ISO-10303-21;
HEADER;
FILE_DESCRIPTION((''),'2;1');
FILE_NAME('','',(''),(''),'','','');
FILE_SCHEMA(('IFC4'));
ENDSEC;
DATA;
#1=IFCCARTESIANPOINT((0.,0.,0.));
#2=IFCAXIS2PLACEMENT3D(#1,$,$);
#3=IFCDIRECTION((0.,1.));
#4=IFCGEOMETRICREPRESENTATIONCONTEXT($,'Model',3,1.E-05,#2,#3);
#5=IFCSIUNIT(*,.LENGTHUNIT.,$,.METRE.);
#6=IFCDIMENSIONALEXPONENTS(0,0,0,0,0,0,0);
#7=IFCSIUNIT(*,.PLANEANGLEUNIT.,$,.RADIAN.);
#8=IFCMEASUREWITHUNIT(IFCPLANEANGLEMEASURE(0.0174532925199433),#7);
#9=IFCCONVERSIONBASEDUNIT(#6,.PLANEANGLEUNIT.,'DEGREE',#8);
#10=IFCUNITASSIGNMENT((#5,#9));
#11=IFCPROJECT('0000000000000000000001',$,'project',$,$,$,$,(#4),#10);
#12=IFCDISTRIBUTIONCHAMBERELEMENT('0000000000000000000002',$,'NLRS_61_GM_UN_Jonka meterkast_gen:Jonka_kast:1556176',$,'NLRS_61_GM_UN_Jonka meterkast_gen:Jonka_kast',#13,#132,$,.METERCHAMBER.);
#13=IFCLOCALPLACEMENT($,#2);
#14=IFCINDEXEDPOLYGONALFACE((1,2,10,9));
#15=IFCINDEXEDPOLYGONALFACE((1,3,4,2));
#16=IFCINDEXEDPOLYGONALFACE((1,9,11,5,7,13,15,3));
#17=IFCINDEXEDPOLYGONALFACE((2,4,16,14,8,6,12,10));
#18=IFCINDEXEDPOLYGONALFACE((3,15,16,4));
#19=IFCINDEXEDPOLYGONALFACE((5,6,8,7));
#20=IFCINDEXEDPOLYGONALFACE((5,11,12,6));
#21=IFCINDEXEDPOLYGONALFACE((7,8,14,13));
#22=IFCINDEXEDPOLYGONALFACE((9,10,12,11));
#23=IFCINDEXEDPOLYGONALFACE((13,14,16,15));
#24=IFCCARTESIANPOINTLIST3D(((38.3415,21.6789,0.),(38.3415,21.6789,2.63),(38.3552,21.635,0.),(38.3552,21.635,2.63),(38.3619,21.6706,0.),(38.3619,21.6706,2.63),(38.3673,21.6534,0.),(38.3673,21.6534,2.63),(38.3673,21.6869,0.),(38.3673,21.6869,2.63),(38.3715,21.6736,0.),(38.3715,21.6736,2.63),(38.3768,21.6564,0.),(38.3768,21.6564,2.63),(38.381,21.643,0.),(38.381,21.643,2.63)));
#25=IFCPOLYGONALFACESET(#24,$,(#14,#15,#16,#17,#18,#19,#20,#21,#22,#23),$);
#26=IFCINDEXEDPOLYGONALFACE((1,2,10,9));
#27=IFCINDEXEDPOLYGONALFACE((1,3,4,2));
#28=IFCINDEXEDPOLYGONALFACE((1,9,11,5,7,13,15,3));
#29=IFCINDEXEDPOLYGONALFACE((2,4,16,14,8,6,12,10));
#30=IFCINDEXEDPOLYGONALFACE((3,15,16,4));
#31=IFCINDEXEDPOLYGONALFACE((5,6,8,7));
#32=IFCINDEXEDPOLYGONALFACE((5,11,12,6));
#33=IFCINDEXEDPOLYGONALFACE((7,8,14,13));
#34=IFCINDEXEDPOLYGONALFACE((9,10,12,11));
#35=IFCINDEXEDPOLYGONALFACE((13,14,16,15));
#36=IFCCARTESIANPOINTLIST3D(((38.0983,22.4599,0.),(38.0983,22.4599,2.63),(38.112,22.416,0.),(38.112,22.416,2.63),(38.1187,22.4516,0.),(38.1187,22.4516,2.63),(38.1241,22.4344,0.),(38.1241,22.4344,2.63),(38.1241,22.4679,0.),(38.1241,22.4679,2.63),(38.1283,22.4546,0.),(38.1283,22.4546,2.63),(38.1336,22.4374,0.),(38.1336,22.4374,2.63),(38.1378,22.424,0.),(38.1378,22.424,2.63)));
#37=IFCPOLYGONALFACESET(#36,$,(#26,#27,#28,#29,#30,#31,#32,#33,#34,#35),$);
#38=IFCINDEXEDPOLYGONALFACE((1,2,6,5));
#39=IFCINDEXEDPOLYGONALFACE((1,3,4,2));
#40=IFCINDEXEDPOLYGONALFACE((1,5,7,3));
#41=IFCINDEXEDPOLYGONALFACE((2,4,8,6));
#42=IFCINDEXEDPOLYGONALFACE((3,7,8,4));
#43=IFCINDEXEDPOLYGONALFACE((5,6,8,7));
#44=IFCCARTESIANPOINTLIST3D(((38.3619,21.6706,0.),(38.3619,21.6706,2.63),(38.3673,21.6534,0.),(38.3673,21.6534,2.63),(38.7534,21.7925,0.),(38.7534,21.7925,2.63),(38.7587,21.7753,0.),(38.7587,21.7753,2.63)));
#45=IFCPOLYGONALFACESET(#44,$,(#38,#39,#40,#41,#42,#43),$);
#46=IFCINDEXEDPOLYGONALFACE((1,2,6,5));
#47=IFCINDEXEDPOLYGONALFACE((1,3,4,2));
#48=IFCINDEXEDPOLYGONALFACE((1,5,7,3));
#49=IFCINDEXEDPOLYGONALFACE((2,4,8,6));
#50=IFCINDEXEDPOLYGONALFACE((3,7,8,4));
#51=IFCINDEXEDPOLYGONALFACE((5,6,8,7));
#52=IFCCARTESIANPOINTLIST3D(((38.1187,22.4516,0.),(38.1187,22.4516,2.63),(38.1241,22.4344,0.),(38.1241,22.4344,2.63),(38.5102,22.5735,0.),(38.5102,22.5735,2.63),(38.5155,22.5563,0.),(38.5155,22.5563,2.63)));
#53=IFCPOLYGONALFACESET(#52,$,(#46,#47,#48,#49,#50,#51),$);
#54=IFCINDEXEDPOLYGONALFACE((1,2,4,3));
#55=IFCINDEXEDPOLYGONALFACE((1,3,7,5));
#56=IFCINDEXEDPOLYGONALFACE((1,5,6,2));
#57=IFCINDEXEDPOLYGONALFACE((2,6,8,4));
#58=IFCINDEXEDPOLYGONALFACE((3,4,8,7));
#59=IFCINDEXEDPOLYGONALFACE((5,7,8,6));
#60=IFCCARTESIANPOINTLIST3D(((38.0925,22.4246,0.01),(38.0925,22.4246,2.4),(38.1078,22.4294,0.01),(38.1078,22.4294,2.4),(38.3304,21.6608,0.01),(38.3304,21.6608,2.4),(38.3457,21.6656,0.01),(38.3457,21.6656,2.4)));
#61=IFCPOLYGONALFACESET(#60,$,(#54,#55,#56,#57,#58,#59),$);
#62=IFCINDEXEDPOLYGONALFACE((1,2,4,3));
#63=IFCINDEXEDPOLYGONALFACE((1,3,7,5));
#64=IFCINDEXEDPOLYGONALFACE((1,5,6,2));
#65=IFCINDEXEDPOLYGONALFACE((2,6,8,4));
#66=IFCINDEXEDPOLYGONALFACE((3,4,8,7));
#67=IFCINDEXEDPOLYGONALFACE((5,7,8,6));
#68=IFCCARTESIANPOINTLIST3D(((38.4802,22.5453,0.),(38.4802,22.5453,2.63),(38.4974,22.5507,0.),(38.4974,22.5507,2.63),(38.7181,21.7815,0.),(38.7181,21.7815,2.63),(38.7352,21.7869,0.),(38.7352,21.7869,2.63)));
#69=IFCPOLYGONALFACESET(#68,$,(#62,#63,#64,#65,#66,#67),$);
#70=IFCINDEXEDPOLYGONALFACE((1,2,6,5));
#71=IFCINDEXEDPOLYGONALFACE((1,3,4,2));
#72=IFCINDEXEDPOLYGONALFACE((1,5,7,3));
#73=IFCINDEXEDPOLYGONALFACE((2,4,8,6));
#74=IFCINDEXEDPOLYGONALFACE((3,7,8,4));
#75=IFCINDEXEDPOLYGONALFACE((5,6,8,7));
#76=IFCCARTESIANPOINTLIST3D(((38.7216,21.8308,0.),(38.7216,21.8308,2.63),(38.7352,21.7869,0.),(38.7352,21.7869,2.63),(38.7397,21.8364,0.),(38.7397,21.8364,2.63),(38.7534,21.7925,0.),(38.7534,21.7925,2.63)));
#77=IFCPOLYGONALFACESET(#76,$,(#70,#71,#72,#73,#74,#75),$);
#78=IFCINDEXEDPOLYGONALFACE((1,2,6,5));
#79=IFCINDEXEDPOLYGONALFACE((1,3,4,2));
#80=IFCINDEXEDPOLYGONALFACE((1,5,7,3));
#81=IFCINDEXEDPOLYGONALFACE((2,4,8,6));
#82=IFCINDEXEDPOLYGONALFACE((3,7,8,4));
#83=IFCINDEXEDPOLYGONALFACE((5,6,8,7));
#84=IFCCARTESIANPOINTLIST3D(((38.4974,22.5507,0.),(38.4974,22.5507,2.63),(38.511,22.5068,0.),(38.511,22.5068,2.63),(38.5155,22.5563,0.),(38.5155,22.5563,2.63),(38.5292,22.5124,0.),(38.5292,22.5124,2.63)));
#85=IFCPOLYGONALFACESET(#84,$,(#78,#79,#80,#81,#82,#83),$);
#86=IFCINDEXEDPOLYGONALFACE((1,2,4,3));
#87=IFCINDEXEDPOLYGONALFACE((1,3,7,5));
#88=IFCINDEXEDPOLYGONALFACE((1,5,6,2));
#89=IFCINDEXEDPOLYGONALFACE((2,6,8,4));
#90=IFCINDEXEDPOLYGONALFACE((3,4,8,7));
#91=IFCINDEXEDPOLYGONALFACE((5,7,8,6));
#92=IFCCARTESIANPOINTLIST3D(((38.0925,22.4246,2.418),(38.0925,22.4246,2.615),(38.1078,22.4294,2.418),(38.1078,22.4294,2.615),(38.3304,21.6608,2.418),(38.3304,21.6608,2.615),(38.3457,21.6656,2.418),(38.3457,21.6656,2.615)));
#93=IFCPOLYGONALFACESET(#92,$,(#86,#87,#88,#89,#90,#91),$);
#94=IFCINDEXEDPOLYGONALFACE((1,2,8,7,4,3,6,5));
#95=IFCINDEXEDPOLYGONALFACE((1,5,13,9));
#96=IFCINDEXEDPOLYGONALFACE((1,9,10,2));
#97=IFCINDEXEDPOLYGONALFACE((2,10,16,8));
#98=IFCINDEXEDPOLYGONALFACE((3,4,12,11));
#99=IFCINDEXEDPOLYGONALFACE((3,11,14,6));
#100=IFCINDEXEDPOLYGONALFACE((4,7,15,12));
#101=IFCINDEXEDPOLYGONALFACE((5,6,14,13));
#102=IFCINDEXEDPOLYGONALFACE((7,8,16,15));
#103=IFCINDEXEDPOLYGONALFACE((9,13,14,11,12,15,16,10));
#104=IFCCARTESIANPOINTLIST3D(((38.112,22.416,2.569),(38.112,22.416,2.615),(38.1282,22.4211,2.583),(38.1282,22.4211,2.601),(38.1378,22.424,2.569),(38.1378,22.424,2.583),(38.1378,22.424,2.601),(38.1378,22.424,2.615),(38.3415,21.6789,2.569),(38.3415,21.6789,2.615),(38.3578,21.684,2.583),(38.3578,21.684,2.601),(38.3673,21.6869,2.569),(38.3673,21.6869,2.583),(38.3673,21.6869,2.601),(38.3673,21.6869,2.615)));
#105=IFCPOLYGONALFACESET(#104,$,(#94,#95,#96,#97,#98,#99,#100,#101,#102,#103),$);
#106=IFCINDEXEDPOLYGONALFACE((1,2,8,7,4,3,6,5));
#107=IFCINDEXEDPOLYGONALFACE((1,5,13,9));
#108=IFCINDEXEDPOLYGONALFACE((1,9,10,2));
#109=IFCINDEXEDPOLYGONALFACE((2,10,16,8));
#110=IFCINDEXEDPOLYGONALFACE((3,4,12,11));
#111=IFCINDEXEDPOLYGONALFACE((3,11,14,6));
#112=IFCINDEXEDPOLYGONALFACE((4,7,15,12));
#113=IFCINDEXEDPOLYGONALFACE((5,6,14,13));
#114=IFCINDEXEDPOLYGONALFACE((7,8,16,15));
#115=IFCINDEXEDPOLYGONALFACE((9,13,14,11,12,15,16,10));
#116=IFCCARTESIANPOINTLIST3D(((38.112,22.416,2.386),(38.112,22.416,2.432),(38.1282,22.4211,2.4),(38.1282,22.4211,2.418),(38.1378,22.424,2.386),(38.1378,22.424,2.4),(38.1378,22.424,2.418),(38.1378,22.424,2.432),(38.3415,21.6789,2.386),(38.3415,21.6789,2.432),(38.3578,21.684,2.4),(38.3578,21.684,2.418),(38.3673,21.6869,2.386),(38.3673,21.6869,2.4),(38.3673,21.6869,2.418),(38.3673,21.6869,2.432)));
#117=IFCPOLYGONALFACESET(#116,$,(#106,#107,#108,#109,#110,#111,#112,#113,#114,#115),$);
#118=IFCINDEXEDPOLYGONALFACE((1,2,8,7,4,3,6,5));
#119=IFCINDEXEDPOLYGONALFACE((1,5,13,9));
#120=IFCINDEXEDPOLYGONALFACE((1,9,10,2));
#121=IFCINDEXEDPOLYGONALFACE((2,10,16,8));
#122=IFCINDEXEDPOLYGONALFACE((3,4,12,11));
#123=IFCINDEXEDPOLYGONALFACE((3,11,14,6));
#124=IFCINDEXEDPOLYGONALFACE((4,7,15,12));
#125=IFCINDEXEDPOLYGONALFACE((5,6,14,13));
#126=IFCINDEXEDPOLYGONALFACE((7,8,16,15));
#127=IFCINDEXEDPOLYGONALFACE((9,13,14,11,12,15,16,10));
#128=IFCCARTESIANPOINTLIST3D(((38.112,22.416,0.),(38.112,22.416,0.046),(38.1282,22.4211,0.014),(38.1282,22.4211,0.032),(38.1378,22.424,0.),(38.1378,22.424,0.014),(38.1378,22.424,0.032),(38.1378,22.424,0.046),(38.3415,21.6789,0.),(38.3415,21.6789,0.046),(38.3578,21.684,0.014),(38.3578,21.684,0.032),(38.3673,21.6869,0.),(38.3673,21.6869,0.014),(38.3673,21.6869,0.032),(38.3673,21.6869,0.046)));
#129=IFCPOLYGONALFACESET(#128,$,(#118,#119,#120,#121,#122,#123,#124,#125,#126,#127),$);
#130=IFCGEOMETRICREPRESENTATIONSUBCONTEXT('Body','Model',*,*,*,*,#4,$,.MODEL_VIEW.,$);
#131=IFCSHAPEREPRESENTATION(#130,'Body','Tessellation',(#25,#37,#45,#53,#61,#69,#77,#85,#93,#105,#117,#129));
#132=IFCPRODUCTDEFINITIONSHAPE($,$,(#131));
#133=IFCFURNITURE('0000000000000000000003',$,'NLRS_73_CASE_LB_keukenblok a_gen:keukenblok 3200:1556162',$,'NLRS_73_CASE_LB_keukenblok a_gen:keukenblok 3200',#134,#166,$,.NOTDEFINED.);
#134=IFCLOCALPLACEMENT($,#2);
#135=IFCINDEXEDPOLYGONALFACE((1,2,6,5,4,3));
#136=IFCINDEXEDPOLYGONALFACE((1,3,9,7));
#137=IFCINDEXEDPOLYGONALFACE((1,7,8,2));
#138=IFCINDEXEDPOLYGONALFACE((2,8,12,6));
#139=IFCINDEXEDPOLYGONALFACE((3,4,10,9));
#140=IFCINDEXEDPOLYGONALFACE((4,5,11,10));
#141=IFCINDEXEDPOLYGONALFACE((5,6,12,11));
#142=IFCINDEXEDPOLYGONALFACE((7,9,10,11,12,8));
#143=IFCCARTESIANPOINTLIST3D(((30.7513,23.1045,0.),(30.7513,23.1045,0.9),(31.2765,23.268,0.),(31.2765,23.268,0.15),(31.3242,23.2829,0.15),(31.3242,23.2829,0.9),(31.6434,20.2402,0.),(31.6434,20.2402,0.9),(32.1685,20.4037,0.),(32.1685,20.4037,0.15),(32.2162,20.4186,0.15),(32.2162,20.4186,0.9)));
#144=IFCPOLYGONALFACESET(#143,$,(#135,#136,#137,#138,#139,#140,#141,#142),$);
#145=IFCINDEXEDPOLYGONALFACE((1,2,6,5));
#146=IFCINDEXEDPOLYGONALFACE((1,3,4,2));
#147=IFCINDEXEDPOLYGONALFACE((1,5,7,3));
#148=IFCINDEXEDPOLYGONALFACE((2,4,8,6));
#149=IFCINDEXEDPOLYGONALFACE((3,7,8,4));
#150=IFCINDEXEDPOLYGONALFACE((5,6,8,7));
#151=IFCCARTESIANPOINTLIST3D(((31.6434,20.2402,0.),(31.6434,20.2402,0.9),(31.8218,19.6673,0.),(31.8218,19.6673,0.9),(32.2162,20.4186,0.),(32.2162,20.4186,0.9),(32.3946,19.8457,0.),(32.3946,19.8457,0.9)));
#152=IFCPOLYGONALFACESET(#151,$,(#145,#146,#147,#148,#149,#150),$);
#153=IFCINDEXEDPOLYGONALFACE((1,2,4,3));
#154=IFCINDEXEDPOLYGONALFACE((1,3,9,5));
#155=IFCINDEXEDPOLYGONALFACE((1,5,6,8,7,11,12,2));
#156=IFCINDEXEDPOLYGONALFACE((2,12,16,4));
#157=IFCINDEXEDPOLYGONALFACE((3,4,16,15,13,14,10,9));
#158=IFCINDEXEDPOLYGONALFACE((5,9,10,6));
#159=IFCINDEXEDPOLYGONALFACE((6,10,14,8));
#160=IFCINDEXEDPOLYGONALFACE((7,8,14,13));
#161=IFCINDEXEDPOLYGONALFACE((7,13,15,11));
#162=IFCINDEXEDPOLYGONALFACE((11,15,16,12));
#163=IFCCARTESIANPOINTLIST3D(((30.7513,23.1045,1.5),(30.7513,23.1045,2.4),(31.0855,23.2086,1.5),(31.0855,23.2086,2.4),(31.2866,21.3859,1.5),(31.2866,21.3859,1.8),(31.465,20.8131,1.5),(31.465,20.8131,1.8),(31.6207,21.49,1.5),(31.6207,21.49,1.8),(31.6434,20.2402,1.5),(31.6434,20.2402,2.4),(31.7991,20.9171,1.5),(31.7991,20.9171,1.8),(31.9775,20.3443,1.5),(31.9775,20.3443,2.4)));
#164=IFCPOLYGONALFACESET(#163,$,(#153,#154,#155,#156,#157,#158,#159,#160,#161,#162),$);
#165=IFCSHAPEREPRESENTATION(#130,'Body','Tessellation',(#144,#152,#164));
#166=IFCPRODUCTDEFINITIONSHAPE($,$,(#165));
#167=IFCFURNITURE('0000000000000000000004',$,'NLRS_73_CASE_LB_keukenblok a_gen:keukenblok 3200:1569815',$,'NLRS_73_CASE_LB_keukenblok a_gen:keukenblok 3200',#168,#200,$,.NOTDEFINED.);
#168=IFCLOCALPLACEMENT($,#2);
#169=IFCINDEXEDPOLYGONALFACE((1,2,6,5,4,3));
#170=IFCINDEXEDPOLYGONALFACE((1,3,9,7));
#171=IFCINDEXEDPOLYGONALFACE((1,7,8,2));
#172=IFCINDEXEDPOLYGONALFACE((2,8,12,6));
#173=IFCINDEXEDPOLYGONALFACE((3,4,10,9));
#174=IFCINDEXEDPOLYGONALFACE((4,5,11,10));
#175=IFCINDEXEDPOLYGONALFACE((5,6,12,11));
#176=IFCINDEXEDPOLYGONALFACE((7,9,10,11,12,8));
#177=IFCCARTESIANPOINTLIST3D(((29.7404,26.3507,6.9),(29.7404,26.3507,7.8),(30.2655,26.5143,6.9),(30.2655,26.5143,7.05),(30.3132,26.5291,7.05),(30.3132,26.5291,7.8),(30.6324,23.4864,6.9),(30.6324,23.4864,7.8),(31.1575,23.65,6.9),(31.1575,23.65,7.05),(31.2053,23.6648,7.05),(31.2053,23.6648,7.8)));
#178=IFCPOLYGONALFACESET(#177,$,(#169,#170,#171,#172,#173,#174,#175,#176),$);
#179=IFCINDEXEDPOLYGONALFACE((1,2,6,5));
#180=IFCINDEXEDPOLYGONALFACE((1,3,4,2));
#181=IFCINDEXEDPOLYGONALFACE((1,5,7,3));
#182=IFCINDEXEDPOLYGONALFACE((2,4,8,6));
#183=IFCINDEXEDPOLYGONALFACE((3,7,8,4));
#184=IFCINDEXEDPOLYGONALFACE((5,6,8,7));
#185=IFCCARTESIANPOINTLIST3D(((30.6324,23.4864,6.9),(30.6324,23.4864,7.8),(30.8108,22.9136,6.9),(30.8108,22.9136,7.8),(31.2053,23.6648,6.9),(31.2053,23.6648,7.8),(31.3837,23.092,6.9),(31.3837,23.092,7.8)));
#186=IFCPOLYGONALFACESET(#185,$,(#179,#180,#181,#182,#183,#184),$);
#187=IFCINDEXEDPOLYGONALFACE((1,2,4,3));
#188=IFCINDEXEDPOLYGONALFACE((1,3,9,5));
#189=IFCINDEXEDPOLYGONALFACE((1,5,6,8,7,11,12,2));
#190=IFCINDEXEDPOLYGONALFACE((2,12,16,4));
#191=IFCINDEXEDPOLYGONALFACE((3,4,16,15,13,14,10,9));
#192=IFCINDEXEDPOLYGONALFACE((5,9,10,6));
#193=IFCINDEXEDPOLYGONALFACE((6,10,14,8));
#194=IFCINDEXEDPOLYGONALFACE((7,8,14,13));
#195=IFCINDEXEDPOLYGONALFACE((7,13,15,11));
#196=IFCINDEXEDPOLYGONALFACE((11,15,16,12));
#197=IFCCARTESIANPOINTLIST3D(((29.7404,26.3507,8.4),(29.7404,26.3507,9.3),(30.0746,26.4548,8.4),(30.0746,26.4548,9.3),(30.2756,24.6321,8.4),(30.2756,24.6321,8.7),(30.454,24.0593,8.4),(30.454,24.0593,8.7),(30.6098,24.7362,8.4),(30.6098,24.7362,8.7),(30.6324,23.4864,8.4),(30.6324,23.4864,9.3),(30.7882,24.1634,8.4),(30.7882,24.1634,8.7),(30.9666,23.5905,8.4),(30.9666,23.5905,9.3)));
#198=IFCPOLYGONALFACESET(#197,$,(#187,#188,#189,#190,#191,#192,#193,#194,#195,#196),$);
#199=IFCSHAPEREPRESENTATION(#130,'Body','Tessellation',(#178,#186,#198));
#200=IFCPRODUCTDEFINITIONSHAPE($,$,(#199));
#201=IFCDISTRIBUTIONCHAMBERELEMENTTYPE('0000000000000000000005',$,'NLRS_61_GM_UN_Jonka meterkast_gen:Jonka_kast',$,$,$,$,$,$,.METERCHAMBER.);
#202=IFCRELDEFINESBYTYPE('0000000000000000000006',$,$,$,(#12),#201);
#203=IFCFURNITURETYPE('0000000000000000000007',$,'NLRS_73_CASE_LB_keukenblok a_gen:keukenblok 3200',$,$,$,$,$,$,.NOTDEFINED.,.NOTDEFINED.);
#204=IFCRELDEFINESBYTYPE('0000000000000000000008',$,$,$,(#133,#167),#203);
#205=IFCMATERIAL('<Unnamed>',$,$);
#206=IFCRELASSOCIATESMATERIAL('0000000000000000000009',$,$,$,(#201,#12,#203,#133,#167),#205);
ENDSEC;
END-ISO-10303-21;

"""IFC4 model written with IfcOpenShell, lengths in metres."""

from ifc_helpers import new_model, entity, si_unit, converted_unit, direction, frame, origin, place, context, subcontext, project, indexed_curve, outline, extrude, source, transform, mapped, material, type_object, type_shapes, element, save


model = new_model("IFC4")

# Units and contexts
model_context = context("Model", 3, precision=1e-05, world=origin(), true_north=direction((0.0, 1.0)))
body_context = subcontext(model_context, "Body", "Model", "MODEL_VIEW")
ifc_project = project(units=[si_unit("LENGTHUNIT", "METRE"), converted_unit("PLANEANGLEUNIT", "DEGREE", entity("IfcPlaneAngleMeasure", 0.0174532925199433), si_unit("PLANEANGLEUNIT", "RADIAN"), dimensions=[0, 0, 0, 0, 0, 0, 0])], contexts=[model_context])

# Shared definitions
ifc_material = material(Name="<Unnamed>")
distribution_chamber_element_type = type_object("IfcDistributionChamberElementType", Name="NLRS_61_GM_UN_Jonka meterkast_gen:Jonka_kast", PredefinedType="METERCHAMBER", material=ifc_material)
placement_1 = place(None, frame((13.1348, 11.9886, 0.0), z_axis=(0.0, 0.0, 1.0), x_axis=(0.954771, 0.297342, 0.0)))
placement_2 = place(placement_1, origin())
placement_3 = place(placement_2, frame((0.0, 0.0, 6.9)))

# Distribution chamber element
shared_shape_1 = source(origin(), body_context, "Body", "SweptSolid", [
    extrude(outline(indexed_curve([(-0.023, -0.0093), (-0.009, -0.0093), (-0.009, 0.0007), (0.009, 0.0007), (0.009, -0.0093), (0.023, -0.0093), (0.023, 0.0178), (-0.023, 0.0178), (-0.023, -0.0093)], self_intersect=False)), frame((-0.409, 0.4092, 0.0)), (0.0, 0.0, 1.0), 2.63),
    extrude(outline(indexed_curve([(-0.023, -0.0093), (-0.009, -0.0093), (-0.009, 0.0007), (0.009, 0.0007), (0.009, -0.0093), (0.023, -0.0093), (0.023, 0.0178), (-0.023, 0.0178), (-0.023, -0.0093)], self_intersect=False)), frame((0.409, 0.4092, 0.0)), (0.0, 0.0, 1.0), 2.63),
    extrude(outline(indexed_curve([(-0.009, -0.205), (0.009, -0.205), (0.009, 0.205), (-0.009, 0.205), (-0.009, -0.205)], self_intersect=False)), frame((-0.409, 0.205, 0.0)), (0.0, 0.0, 1.0), 2.63),
    extrude(outline(indexed_curve([(-0.009, -0.205), (0.009, -0.205), (0.009, 0.205), (-0.009, 0.205), (-0.009, -0.205)], self_intersect=False)), frame((0.409, 0.205, 0.0)), (0.0, 0.0, 1.0), 2.63),
    extrude(outline(indexed_curve([(-0.008, -0.4), (0.008, -0.4), (0.008, 0.4), (-0.008, 0.4), (-0.008, -0.4)], self_intersect=False)), frame((0.0, 0.435, 0.01), z_axis=(0.0, 0.0, 1.0), x_axis=(0.0, 1.0, 0.0)), (0.0, 0.0, 1.0), 2.39),
    extrude(outline(indexed_curve([(-0.009, -0.4), (0.009, -0.4), (0.009, 0.4), (-0.009, 0.4), (-0.009, -0.4)], self_intersect=False)), frame((0.0, 0.028, 0.0), z_axis=(0.0, 0.0, 1.0), x_axis=(0.0, 1.0, 0.0)), (0.0, 0.0, 1.0), 2.63),
    extrude(outline(indexed_curve([(-0.0095, -0.023), (0.0095, -0.023), (0.0095, 0.023), (-0.0095, 0.023), (-0.0095, -0.023)], self_intersect=False)), frame((-0.377, 0.0095, 0.0), z_axis=(0.0, 0.0, 1.0), x_axis=(0.0, 1.0, 0.0)), (0.0, 0.0, 1.0), 2.63),
    extrude(outline(indexed_curve([(-0.0095, -0.023), (0.0095, -0.023), (0.0095, 0.023), (-0.0095, 0.023), (-0.0095, -0.023)], self_intersect=False)), frame((0.377, 0.0095, 0.0), z_axis=(0.0, 0.0, 1.0), x_axis=(0.0, 1.0, 0.0)), (0.0, 0.0, 1.0), 2.63),
    extrude(outline(indexed_curve([(-0.008, -0.4), (0.008, -0.4), (0.008, 0.4), (-0.008, 0.4), (-0.008, -0.4)], self_intersect=False)), frame((0.0, 0.435, 2.418), z_axis=(0.0, 0.0, 1.0), x_axis=(0.0, 1.0, 0.0)), (0.0, 0.0, 1.0), 0.197),
    extrude(outline(indexed_curve([(-0.0178, -0.023), (0.0093, -0.023), (0.0093, -0.009), (-0.0007, -0.009), (-0.0007, 0.009), (0.0093, 0.009), (0.0093, 0.023), (-0.0178, 0.023), (-0.0178, -0.023)], self_intersect=False)), frame((-0.386, 0.4092, 2.592), z_axis=(1.0, 0.0, 0.0), x_axis=(0.0, -1.0, 0.0)), (0.0, 0.0, 1.0), 0.772),
    extrude(outline(indexed_curve([(-0.0178, -0.023), (0.0093, -0.023), (0.0093, -0.009), (-0.0007, -0.009), (-0.0007, 0.009), (0.0093, 0.009), (0.0093, 0.023), (-0.0178, 0.023), (-0.0178, -0.023)], self_intersect=False)), frame((-0.386, 0.4092, 2.409), z_axis=(1.0, 0.0, 0.0), x_axis=(0.0, -1.0, 0.0)), (0.0, 0.0, 1.0), 0.772),
    extrude(outline(indexed_curve([(-0.0178, -0.023), (0.0093, -0.023), (0.0093, -0.009), (-0.0007, -0.009), (-0.0007, 0.009), (0.0093, 0.009), (0.0093, 0.023), (-0.0178, 0.023), (-0.0178, -0.023)], self_intersect=False)), frame((-0.386, 0.4092, 0.023), z_axis=(1.0, 0.0, 0.0), x_axis=(0.0, -1.0, 0.0)), (0.0, 0.0, 1.0), 0.772),
])
placement_4 = place(placement_2, origin())
placement_5 = place(placement_4, origin())
distribution_chamber_element_1_placement = place(placement_5, frame((27.375, 2.143, 0.0), z_axis=(0.0, 0.0, 1.0), x_axis=(0.0, 1.0, 0.0)))
element("IfcDistributionChamberElement", 1, at=distribution_chamber_element_1_placement, type_object=distribution_chamber_element_type, material=ifc_material, Name="NLRS_61_GM_UN_Jonka meterkast_gen:Jonka_kast:1556176", ObjectType="NLRS_61_GM_UN_Jonka meterkast_gen:Jonka_kast", PredefinedType="METERCHAMBER", context=body_context, shape_type="MappedRepresentation", body=[
    mapped(shared_shape_1, transform((0.0, 0.0, 0.0), scale=1.0)),
])

# Furniture
furniture_type = type_object("IfcFurnitureType", Name="NLRS_73_CASE_LB_keukenblok a_gen:keukenblok 3200", AssemblyPlace="NOTDEFINED", PredefinedType="NOTDEFINED", material=ifc_material)
shared_shape_2 = source(origin(), body_context, "Body", "SweptSolid", [
    extrude(outline(indexed_curve([(-0.35, 0.1667), (-0.35, -0.3833), (0.55, -0.3833), (0.55, 0.2167), (-0.2, 0.2167), (-0.2, 0.1667), (-0.35, 0.1667)], self_intersect=False)), frame((0.0, 0.3833, 0.35), z_axis=(-1.0, 0.0, 0.0), x_axis=(0.0, 0.0, 1.0)), (0.0, 0.0, -1.0), 3.0),
    extrude(outline(indexed_curve([(-0.3, -0.3), (0.3, -0.3), (0.3, 0.3), (-0.3, 0.3), (-0.3, -0.3)], self_intersect=False)), frame((3.3, 0.3, 0.0), z_axis=(0.0, 0.0, 1.0), x_axis=(0.0, 1.0, 0.0)), (0.0, 0.0, 1.0), 0.9),
    extrude(outline(indexed_curve([(-1.2, -0.3), (-0.6, -0.3), (-0.6, 0.0), (0.0, 0.0), (0.0, -0.3), (1.8, -0.3), (1.8, 0.6), (-1.2, 0.6), (-1.2, -0.3)], self_intersect=False)), frame((1.8, 0.0, 1.8), z_axis=(0.0, 1.0, 0.0), x_axis=(-1.0, 0.0, 0.0)), (0.0, 0.0, 1.0), 0.35),
])
type_shapes(furniture_type, [shared_shape_2])
placement_6 = place(placement_4, origin())
furniture_1_placement = place(placement_6, frame((20.125, 5.375, 0.0), z_axis=(0.0, 0.0, 1.0), x_axis=(0.0, -1.0, 0.0)))
element("IfcFurniture", 2, at=furniture_1_placement, type_object=furniture_type, material=ifc_material, Name="NLRS_73_CASE_LB_keukenblok a_gen:keukenblok 3200:1556162", ObjectType="NLRS_73_CASE_LB_keukenblok a_gen:keukenblok 3200", PredefinedType="NOTDEFINED", context=body_context, shape_type="MappedRepresentation", body=[
    mapped(shared_shape_2, transform((0.0, 0.0, 0.0), scale=1.0)),
])
placement_7 = place(placement_3, origin())
furniture_2_placement = place(placement_7, frame((20.125, 8.775, 0.0), z_axis=(0.0, 0.0, 1.0), x_axis=(0.0, -1.0, 0.0)))
element("IfcFurniture", 3, at=furniture_2_placement, type_object=furniture_type, material=ifc_material, Name="NLRS_73_CASE_LB_keukenblok a_gen:keukenblok 3200:1569815", ObjectType="NLRS_73_CASE_LB_keukenblok a_gen:keukenblok 3200", PredefinedType="NOTDEFINED", context=body_context, shape_type="MappedRepresentation", body=[
    mapped(shared_shape_2, transform((0.0, 0.0, 0.0), scale=1.0)),
])

save(model, "model.ifc")
